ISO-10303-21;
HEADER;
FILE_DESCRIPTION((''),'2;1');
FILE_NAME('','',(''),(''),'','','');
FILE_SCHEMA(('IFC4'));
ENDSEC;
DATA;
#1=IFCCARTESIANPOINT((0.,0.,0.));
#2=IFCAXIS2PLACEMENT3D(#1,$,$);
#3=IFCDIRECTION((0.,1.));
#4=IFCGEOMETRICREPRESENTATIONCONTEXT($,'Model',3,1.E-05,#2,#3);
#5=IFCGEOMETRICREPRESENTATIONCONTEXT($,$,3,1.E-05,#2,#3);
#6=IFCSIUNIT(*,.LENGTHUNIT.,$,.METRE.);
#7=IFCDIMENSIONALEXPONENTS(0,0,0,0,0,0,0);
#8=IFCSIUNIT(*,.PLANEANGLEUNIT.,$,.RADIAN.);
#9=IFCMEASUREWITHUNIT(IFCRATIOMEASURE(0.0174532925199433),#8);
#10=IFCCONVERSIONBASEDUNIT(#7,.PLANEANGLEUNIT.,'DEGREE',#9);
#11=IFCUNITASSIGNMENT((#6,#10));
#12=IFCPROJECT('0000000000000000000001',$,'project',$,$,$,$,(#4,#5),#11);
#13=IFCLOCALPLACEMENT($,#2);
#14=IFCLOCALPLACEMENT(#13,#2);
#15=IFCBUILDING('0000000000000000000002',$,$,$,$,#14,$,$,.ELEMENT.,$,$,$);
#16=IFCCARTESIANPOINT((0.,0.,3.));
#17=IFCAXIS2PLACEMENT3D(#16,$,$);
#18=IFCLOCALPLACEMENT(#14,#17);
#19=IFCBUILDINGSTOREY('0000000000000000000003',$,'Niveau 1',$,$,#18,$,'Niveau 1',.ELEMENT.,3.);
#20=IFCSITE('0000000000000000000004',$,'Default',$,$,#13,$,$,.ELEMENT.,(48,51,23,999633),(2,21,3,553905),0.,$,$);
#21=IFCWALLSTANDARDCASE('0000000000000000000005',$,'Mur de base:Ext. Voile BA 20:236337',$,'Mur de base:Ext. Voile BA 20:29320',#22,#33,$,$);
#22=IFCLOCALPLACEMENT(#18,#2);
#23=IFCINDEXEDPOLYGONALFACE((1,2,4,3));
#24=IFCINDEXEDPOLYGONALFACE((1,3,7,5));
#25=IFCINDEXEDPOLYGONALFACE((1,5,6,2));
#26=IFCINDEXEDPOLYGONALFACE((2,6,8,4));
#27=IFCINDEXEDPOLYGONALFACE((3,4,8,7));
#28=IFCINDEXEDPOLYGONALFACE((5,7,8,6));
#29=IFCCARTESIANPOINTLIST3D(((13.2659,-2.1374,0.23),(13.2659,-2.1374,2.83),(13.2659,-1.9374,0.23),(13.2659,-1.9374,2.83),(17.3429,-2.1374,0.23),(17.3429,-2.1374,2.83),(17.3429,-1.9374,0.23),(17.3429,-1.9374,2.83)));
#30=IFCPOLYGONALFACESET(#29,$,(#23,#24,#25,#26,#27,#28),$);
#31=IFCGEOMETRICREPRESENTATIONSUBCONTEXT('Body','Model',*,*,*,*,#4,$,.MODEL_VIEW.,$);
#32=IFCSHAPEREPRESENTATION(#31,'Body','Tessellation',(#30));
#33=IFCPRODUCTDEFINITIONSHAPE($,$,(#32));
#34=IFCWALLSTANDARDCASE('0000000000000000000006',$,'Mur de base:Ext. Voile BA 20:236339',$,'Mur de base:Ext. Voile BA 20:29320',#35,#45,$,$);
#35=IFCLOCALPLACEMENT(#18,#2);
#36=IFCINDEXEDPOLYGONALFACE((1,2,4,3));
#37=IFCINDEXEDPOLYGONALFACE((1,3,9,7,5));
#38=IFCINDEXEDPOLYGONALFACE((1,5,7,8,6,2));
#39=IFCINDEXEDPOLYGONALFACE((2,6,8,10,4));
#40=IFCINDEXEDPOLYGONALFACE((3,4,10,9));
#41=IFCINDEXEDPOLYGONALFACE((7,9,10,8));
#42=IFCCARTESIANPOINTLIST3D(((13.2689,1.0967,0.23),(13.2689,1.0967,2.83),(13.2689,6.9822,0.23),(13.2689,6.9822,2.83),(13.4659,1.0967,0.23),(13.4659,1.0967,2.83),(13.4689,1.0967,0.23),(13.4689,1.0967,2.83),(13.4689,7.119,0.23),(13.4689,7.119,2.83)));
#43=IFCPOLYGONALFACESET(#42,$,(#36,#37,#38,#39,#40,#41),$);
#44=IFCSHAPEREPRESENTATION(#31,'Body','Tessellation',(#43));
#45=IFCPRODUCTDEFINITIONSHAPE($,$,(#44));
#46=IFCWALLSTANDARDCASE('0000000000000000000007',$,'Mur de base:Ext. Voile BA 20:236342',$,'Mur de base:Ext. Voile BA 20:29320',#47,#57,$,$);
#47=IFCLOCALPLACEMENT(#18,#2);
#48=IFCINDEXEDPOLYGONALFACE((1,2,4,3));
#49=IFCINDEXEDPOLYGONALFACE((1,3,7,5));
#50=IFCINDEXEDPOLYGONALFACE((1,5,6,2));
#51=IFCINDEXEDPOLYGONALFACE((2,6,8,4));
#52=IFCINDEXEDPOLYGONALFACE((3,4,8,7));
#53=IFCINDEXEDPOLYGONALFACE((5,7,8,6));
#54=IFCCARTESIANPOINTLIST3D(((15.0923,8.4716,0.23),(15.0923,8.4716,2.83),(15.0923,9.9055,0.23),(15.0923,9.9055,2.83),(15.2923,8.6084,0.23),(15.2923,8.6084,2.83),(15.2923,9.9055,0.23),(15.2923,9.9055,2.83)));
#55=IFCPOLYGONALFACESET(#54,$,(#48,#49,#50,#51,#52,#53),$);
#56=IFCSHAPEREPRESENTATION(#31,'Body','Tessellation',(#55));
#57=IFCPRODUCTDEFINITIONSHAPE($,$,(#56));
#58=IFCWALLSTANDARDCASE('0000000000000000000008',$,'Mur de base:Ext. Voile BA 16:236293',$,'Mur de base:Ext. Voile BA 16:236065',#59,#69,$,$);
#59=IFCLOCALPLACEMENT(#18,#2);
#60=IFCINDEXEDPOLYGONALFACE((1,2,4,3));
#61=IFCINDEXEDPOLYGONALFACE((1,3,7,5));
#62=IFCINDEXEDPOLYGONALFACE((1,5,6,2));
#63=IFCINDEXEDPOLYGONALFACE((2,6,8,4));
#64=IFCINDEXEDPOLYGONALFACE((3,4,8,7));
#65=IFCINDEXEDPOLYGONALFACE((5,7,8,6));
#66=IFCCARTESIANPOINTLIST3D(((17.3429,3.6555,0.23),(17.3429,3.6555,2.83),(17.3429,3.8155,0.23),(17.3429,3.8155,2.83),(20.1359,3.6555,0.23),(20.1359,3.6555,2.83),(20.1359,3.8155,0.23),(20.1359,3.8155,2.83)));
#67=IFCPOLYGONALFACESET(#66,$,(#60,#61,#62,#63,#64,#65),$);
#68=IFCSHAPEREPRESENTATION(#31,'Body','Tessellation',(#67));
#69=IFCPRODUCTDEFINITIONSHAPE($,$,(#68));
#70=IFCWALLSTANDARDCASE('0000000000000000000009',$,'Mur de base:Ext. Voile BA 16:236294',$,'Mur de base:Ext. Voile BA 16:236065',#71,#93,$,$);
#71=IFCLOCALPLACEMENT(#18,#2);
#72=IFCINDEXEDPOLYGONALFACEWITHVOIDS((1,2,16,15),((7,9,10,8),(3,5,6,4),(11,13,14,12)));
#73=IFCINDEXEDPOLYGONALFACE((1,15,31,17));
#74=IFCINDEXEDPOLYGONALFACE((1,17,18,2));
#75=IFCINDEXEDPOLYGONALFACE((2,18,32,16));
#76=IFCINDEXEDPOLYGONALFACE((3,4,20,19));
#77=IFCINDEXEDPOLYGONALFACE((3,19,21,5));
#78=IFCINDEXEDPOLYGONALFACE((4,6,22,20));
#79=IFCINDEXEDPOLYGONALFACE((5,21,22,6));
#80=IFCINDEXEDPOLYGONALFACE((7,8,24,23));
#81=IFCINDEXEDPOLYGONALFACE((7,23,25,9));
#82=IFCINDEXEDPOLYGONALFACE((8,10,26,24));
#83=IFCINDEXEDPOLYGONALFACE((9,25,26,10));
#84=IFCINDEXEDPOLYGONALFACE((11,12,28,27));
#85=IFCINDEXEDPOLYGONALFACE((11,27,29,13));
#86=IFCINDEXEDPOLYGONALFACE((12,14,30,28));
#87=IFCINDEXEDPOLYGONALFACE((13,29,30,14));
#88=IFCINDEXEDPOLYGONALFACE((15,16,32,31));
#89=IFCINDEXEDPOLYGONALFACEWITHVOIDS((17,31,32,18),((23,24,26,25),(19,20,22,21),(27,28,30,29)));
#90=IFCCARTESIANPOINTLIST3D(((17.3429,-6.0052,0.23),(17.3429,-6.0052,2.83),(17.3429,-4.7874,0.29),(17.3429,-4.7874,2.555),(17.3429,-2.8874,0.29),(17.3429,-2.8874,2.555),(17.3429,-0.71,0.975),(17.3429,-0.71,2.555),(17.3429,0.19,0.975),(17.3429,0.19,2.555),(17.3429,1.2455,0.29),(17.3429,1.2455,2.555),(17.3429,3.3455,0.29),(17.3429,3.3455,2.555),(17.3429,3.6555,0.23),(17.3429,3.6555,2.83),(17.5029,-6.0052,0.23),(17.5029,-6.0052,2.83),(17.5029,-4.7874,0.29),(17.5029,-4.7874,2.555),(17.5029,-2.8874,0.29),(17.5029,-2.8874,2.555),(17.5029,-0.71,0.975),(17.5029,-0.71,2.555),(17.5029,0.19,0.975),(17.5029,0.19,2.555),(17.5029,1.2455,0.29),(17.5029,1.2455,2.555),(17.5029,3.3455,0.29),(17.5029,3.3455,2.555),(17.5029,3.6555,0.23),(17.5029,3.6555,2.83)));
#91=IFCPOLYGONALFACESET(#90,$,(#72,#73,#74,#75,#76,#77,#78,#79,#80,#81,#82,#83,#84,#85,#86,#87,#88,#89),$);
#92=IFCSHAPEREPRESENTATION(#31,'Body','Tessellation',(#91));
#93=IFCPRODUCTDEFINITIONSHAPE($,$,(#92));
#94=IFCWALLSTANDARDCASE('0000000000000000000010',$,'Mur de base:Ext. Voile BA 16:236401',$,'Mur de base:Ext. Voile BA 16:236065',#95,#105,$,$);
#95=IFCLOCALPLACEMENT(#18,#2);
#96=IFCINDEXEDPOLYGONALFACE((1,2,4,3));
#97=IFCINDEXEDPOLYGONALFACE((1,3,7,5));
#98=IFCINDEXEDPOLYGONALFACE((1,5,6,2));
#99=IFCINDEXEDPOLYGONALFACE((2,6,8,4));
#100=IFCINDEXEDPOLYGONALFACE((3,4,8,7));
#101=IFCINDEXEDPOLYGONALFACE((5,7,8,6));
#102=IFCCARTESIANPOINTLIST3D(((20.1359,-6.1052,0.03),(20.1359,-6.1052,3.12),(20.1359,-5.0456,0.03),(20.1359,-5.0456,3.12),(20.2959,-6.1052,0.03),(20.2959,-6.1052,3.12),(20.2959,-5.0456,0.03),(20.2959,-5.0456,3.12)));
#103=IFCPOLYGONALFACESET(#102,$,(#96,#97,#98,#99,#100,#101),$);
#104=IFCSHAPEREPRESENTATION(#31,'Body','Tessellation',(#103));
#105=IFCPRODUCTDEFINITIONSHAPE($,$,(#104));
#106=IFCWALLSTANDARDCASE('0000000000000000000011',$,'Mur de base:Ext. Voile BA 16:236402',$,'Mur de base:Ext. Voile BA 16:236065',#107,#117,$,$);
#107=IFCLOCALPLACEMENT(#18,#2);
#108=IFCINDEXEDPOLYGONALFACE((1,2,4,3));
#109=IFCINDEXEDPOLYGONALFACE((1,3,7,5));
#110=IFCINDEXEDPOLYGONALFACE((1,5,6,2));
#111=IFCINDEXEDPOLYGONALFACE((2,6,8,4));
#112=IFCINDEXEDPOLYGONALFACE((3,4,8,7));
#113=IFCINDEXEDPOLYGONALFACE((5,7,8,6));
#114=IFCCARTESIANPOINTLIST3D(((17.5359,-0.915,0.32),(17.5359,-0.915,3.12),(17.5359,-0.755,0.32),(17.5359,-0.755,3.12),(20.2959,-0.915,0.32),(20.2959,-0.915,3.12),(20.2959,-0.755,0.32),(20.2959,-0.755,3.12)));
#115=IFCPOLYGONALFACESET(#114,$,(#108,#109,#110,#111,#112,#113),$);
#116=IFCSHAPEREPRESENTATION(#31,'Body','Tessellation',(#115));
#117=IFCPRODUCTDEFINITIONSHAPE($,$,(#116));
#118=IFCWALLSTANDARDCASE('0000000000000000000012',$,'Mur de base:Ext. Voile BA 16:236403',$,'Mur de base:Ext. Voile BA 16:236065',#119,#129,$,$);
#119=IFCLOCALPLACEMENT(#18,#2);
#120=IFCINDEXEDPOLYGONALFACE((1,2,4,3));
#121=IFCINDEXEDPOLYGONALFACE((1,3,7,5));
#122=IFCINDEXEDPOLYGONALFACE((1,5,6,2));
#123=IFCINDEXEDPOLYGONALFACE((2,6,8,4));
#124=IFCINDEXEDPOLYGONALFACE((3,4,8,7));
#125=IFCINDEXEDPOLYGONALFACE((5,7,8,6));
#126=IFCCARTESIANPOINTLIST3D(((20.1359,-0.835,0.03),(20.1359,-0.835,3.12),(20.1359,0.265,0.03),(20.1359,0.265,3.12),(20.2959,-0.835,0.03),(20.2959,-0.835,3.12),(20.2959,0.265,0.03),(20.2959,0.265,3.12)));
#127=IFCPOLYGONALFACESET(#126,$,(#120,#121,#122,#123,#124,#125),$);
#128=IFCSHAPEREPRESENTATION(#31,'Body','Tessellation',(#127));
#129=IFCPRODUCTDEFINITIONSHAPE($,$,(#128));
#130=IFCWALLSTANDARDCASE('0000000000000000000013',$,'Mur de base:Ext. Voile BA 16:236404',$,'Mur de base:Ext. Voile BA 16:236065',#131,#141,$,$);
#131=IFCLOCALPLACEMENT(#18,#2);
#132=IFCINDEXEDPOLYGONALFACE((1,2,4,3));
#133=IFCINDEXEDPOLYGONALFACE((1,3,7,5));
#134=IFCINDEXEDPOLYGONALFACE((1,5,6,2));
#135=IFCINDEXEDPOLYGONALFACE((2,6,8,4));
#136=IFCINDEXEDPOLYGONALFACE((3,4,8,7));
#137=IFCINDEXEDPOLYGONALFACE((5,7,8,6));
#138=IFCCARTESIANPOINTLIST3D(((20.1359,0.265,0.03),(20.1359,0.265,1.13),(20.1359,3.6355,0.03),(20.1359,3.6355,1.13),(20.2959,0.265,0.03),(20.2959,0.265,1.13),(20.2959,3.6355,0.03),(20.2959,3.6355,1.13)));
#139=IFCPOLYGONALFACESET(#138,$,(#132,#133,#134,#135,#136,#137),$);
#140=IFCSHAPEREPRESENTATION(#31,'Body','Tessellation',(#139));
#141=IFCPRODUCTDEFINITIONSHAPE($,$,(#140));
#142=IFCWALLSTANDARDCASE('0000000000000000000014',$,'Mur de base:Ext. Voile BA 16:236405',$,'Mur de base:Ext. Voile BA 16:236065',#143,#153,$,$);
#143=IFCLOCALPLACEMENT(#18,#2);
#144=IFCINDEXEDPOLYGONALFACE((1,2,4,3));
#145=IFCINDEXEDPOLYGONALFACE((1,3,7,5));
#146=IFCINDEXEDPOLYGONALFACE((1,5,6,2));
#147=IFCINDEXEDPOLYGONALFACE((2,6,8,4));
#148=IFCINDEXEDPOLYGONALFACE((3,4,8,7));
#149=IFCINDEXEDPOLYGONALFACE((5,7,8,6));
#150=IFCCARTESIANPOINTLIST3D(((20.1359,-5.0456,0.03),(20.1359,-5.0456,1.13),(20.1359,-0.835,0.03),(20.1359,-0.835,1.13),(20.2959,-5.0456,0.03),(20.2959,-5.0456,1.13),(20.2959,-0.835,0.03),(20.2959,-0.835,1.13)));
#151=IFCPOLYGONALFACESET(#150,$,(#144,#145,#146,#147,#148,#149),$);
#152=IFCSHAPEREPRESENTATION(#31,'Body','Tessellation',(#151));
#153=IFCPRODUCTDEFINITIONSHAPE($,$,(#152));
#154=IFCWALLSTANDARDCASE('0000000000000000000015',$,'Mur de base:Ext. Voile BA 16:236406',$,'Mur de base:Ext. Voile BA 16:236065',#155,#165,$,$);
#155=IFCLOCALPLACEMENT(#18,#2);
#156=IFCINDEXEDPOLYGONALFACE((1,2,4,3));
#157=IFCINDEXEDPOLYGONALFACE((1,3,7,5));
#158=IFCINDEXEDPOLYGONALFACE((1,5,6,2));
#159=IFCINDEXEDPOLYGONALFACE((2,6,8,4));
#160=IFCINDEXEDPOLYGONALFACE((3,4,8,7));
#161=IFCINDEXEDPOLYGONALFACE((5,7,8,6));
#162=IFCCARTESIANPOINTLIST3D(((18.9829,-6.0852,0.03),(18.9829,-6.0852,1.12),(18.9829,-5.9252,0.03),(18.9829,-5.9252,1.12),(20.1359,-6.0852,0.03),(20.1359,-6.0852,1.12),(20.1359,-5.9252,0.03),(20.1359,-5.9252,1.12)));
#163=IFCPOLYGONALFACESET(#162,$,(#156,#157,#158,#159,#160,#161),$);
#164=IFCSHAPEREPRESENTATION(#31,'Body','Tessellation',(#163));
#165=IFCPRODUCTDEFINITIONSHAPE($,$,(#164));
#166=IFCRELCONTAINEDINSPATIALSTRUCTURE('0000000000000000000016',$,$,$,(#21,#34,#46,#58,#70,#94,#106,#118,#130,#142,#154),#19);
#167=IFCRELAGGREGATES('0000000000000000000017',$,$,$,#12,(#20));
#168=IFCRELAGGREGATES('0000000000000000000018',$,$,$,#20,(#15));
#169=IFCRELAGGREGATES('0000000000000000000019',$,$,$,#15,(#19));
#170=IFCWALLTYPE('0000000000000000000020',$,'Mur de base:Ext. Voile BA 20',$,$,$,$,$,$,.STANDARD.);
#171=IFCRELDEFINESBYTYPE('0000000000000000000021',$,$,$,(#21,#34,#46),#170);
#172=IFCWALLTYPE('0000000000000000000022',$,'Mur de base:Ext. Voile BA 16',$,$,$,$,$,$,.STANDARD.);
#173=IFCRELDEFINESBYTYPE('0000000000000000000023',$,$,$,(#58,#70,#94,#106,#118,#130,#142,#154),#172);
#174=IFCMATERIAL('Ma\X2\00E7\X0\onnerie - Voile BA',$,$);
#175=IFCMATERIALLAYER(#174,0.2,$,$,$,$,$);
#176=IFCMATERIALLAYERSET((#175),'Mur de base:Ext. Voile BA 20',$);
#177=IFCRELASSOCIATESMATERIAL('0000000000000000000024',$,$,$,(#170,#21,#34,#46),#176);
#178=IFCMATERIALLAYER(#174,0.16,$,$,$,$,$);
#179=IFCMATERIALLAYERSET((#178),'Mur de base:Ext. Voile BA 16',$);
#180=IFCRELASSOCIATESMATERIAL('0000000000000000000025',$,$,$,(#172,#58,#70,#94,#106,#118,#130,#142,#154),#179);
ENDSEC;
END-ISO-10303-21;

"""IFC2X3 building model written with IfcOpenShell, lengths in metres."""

from ifc_helpers import new_model, entity, si_unit, converted_unit, direction, frame, frame_2d, origin, origin_2d_with_axis, place, context, subcontext, project, spatial, polyline, rectangle, outline, extrude, material, layer, layer_set, layer_usage, type_object, element, save


model = new_model("IFC2X3")

# Units and contexts
model_context = context("Model", 3, precision=1e-05, world=origin(), true_north=direction((0.0, 1.0)))
context_of_model = context(None, 3, precision=1e-05, world=origin(), true_north=direction((0.0, 1.0)))
body_context = subcontext(model_context, "Body", "Model", "MODEL_VIEW")
ifc_project = project(units=[si_unit("LENGTHUNIT", "METRE"), converted_unit("PLANEANGLEUNIT", "DEGREE", entity("IfcRatioMeasure", 0.0174532925199433), si_unit("PLANEANGLEUNIT", "RADIAN"), dimensions=[0, 0, 0, 0, 0, 0, 0])], contexts=[model_context, context_of_model])

# Site, building, storey
site_placement = place(None, origin())
site = spatial("IfcSite", under=ifc_project, at=site_placement, Name="Default", CompositionType="ELEMENT", RefLatitude=(48, 51, 23, 999633), RefLongitude=(2, 21, 3, 553905), RefElevation=0.0)
building_placement = place(site_placement, origin())
building = spatial("IfcBuilding", under=site, at=building_placement, CompositionType="ELEMENT")
storey_placement = place(building_placement, frame((0.0, 0.0, 3.0)))
storey = spatial("IfcBuildingStorey", under=building, at=storey_placement, Name="Niveau 1", LongName="Niveau 1", CompositionType="ELEMENT", Elevation=3.0)

# Walls
ifc_material = material(Name="Maçonnerie - Voile BA")
ifc_layer_1 = layer(ifc_material, 0.2)
ifc_layer_set_1 = layer_set([ifc_layer_1], Name="Mur de base:Ext. Voile BA 20")
ifc_layer_usage_1 = layer_usage(ifc_layer_set_1, "AXIS2", "NEGATIVE", 0.1)
wall_type_1 = type_object("IfcWallType", Name="Mur de base:Ext. Voile BA 20", PredefinedType="STANDARD", material=ifc_layer_set_1)
wall_1_placement = place(storey_placement, frame((17.3429, -2.0374, 0.23), z_axis=(0.0, 0.0, 1.0), x_axis=(-1.0, 0.0, 0.0)))
element("IfcWallStandardCase", 1, at=wall_1_placement, inside=storey, type_object=wall_type_1, material=ifc_layer_usage_1, Name="Mur de base:Ext. Voile BA 20:236337", ObjectType="Mur de base:Ext. Voile BA 20:29320", context=body_context, shape_type="SweptSolid", body=[
    extrude(rectangle(XDim=4.077, YDim=0.2, at=frame_2d((2.0385, 0.0), x_axis=(-1.0, 0.0))), origin(), (0.0, 0.0, 1.0), 2.6),
])
ifc_layer_usage_2 = layer_usage(ifc_layer_set_1, "AXIS2", "NEGATIVE", 0.1)
wall_2_placement = place(storey_placement, frame((13.3689, 1.0967, 0.23), z_axis=(0.0, 0.0, 1.0), x_axis=(0.0, 1.0, 0.0)))
element("IfcWallStandardCase", 2, at=wall_2_placement, inside=storey, type_object=wall_type_1, material=ifc_layer_usage_2, Name="Mur de base:Ext. Voile BA 20:236339", ObjectType="Mur de base:Ext. Voile BA 20:29320", context=body_context, shape_type="SweptSolid", body=[
    extrude(outline(polyline([(6.0223, -0.1), (5.8855, 0.1), (0.0, 0.1), (0.0, -0.097), (0.0, -0.1), (6.0223, -0.1)])), origin(), (0.0, 0.0, 1.0), 2.6),
])
ifc_layer_usage_3 = layer_usage(ifc_layer_set_1, "AXIS2", "NEGATIVE", 0.1)
wall_3_placement = place(storey_placement, frame((15.1923, 8.4716, 0.23), z_axis=(0.0, 0.0, 1.0), x_axis=(0.0, 1.0, 0.0)))
element("IfcWallStandardCase", 3, at=wall_3_placement, inside=storey, type_object=wall_type_1, material=ifc_layer_usage_3, Name="Mur de base:Ext. Voile BA 20:236342", ObjectType="Mur de base:Ext. Voile BA 20:29320", context=body_context, shape_type="SweptSolid", body=[
    extrude(outline(polyline([(1.4338, -0.1), (1.4338, 0.1), (0.0, 0.1), (0.1368, -0.1), (1.4338, -0.1)])), origin(), (0.0, 0.0, 1.0), 2.6),
])
ifc_layer_2 = layer(ifc_material, 0.16)
ifc_layer_set_2 = layer_set([ifc_layer_2], Name="Mur de base:Ext. Voile BA 16")
ifc_layer_usage_4 = layer_usage(ifc_layer_set_2, "AXIS2", "NEGATIVE", 0.08)
wall_type_2 = type_object("IfcWallType", Name="Mur de base:Ext. Voile BA 16", PredefinedType="STANDARD", material=ifc_layer_set_2)
wall_4_placement = place(storey_placement, frame((20.1359, 3.7355, 0.23), z_axis=(0.0, 0.0, 1.0), x_axis=(-1.0, 0.0, 0.0)))
element("IfcWallStandardCase", 4, at=wall_4_placement, inside=storey, type_object=wall_type_2, material=ifc_layer_usage_4, Name="Mur de base:Ext. Voile BA 16:236293", ObjectType="Mur de base:Ext. Voile BA 16:236065", context=body_context, shape_type="SweptSolid", body=[
    extrude(rectangle(XDim=2.793, YDim=0.16, at=frame_2d((1.3965, 0.0), x_axis=(-1.0, 0.0))), origin(), (0.0, 0.0, 1.0), 2.6),
])

# Wall, openings
ifc_layer_usage_5 = layer_usage(ifc_layer_set_2, "AXIS2", "NEGATIVE", 0.08)
wall_5_placement = place(storey_placement, frame((17.4229, 3.6555, 0.23), z_axis=(0.0, 0.0, 1.0), x_axis=(0.0, -1.0, 0.0)))
wall_5 = element("IfcWallStandardCase", 5, at=wall_5_placement, inside=storey, type_object=wall_type_2, material=ifc_layer_usage_5, Name="Mur de base:Ext. Voile BA 16:236294", ObjectType="Mur de base:Ext. Voile BA 16:236065", context=body_context, shape_type="SweptSolid", body=[
    extrude(rectangle(XDim=9.6606, YDim=0.16, at=frame_2d((4.8303, 0.0), x_axis=(-1.0, 0.0))), origin(), (0.0, 0.0, 1.0), 2.6),
])
opening_1_placement = place(wall_5_placement, origin())
element("IfcOpeningElement", 6, at=opening_1_placement, cuts=wall_5, ObjectType="Opening", context=body_context, shape_type="SweptSolid", body=[
    extrude(rectangle(XDim=2.265, YDim=1.9, at=origin_2d_with_axis()), frame((7.4928, -0.08, 1.1925), z_axis=(0.0, 1.0, 0.0), x_axis=(0.0, 0.0, -1.0)), (0.0, 0.0, 1.0), 0.16),
])
opening_2_placement = place(wall_5_placement, origin())
element("IfcOpeningElement", 7, at=opening_2_placement, cuts=wall_5, ObjectType="Opening", context=body_context, shape_type="SweptSolid", body=[
    extrude(rectangle(XDim=1.58, YDim=0.9, at=frame_2d((0.0, 0.0), x_axis=(1.0, 0.0))), frame((3.9155, -0.08, 1.535), z_axis=(0.0, 1.0, 0.0), x_axis=(0.0, 0.0, -1.0)), (0.0, 0.0, 1.0), 0.16),
])
opening_3_placement = place(wall_5_placement, origin())
element("IfcOpeningElement", 8, at=opening_3_placement, cuts=wall_5, ObjectType="Opening", context=body_context, shape_type="SweptSolid", body=[
    extrude(rectangle(XDim=2.265, YDim=2.1, at=origin_2d_with_axis()), frame((1.36, -0.08, 1.1925), z_axis=(0.0, 1.0, 0.0), x_axis=(0.0, 0.0, -1.0)), (0.0, 0.0, 1.0), 0.16),
])

# Walls
ifc_layer_usage_6 = layer_usage(ifc_layer_set_2, "AXIS2", "NEGATIVE", 0.08)
wall_6_placement = place(storey_placement, frame((20.2159, -6.1052, 0.03), z_axis=(0.0, 0.0, 1.0), x_axis=(0.0, 1.0, 0.0)))
element("IfcWallStandardCase", 9, at=wall_6_placement, inside=storey, type_object=wall_type_2, material=ifc_layer_usage_6, Name="Mur de base:Ext. Voile BA 16:236401", ObjectType="Mur de base:Ext. Voile BA 16:236065", context=body_context, shape_type="SweptSolid", body=[
    extrude(rectangle(XDim=1.0595, YDim=0.16, at=frame_2d((0.5298, 0.0), x_axis=(-1.0, 0.0))), origin(), (0.0, 0.0, 1.0), 3.09),
])
ifc_layer_usage_7 = layer_usage(ifc_layer_set_2, "AXIS2", "NEGATIVE", 0.08)
wall_7_placement = place(storey_placement, frame((17.5359, -0.835, 0.32)))
element("IfcWallStandardCase", 10, at=wall_7_placement, inside=storey, type_object=wall_type_2, material=ifc_layer_usage_7, Name="Mur de base:Ext. Voile BA 16:236402", ObjectType="Mur de base:Ext. Voile BA 16:236065", context=body_context, shape_type="SweptSolid", body=[
    extrude(rectangle(XDim=2.76, YDim=0.16, at=frame_2d((1.38, 0.0), x_axis=(-1.0, 0.0))), origin(), (0.0, 0.0, 1.0), 2.8),
])
ifc_layer_usage_8 = layer_usage(ifc_layer_set_2, "AXIS2", "NEGATIVE", 0.08)
wall_8_placement = place(storey_placement, frame((20.2159, -0.835, 0.03), z_axis=(0.0, 0.0, 1.0), x_axis=(0.0, 1.0, 0.0)))
element("IfcWallStandardCase", 11, at=wall_8_placement, inside=storey, type_object=wall_type_2, material=ifc_layer_usage_8, Name="Mur de base:Ext. Voile BA 16:236403", ObjectType="Mur de base:Ext. Voile BA 16:236065", context=body_context, shape_type="SweptSolid", body=[
    extrude(rectangle(XDim=1.1, YDim=0.16, at=frame_2d((0.55, 0.0), x_axis=(-1.0, 0.0))), origin(), (0.0, 0.0, 1.0), 3.09),
])
ifc_layer_usage_9 = layer_usage(ifc_layer_set_2, "AXIS2", "NEGATIVE", 0.08)
wall_9_placement = place(storey_placement, frame((20.2159, 0.265, 0.03), z_axis=(0.0, 0.0, 1.0), x_axis=(0.0, 1.0, 0.0)))
element("IfcWallStandardCase", 12, at=wall_9_placement, inside=storey, type_object=wall_type_2, material=ifc_layer_usage_9, Name="Mur de base:Ext. Voile BA 16:236404", ObjectType="Mur de base:Ext. Voile BA 16:236065", context=body_context, shape_type="SweptSolid", body=[
    extrude(rectangle(XDim=3.3704, YDim=0.16, at=frame_2d((1.6852, 0.0), x_axis=(-1.0, 0.0))), origin(), (0.0, 0.0, 1.0), 1.1),
])
ifc_layer_usage_10 = layer_usage(ifc_layer_set_2, "AXIS2", "NEGATIVE", 0.08)
wall_10_placement = place(storey_placement, frame((20.2159, -5.0456, 0.03), z_axis=(0.0, 0.0, 1.0), x_axis=(0.0, 1.0, 0.0)))
element("IfcWallStandardCase", 13, at=wall_10_placement, inside=storey, type_object=wall_type_2, material=ifc_layer_usage_10, Name="Mur de base:Ext. Voile BA 16:236405", ObjectType="Mur de base:Ext. Voile BA 16:236065", context=body_context, shape_type="SweptSolid", body=[
    extrude(rectangle(XDim=4.2107, YDim=0.16, at=frame_2d((2.1053, 0.0), x_axis=(-1.0, 0.0))), origin(), (0.0, 0.0, 1.0), 1.1),
])
ifc_layer_usage_11 = layer_usage(ifc_layer_set_2, "AXIS2", "NEGATIVE", 0.08)
wall_11_placement = place(storey_placement, frame((18.9829, -6.0052, 0.03)))
element("IfcWallStandardCase", 14, at=wall_11_placement, inside=storey, type_object=wall_type_2, material=ifc_layer_usage_11, Name="Mur de base:Ext. Voile BA 16:236406", ObjectType="Mur de base:Ext. Voile BA 16:236065", context=body_context, shape_type="SweptSolid", body=[
    extrude(rectangle(XDim=1.153, YDim=0.16, at=frame_2d((0.5765, 0.0), x_axis=(-1.0, 0.0))), origin(), (0.0, 0.0, 1.0), 1.09),
])

save(model, "model.ifc")
